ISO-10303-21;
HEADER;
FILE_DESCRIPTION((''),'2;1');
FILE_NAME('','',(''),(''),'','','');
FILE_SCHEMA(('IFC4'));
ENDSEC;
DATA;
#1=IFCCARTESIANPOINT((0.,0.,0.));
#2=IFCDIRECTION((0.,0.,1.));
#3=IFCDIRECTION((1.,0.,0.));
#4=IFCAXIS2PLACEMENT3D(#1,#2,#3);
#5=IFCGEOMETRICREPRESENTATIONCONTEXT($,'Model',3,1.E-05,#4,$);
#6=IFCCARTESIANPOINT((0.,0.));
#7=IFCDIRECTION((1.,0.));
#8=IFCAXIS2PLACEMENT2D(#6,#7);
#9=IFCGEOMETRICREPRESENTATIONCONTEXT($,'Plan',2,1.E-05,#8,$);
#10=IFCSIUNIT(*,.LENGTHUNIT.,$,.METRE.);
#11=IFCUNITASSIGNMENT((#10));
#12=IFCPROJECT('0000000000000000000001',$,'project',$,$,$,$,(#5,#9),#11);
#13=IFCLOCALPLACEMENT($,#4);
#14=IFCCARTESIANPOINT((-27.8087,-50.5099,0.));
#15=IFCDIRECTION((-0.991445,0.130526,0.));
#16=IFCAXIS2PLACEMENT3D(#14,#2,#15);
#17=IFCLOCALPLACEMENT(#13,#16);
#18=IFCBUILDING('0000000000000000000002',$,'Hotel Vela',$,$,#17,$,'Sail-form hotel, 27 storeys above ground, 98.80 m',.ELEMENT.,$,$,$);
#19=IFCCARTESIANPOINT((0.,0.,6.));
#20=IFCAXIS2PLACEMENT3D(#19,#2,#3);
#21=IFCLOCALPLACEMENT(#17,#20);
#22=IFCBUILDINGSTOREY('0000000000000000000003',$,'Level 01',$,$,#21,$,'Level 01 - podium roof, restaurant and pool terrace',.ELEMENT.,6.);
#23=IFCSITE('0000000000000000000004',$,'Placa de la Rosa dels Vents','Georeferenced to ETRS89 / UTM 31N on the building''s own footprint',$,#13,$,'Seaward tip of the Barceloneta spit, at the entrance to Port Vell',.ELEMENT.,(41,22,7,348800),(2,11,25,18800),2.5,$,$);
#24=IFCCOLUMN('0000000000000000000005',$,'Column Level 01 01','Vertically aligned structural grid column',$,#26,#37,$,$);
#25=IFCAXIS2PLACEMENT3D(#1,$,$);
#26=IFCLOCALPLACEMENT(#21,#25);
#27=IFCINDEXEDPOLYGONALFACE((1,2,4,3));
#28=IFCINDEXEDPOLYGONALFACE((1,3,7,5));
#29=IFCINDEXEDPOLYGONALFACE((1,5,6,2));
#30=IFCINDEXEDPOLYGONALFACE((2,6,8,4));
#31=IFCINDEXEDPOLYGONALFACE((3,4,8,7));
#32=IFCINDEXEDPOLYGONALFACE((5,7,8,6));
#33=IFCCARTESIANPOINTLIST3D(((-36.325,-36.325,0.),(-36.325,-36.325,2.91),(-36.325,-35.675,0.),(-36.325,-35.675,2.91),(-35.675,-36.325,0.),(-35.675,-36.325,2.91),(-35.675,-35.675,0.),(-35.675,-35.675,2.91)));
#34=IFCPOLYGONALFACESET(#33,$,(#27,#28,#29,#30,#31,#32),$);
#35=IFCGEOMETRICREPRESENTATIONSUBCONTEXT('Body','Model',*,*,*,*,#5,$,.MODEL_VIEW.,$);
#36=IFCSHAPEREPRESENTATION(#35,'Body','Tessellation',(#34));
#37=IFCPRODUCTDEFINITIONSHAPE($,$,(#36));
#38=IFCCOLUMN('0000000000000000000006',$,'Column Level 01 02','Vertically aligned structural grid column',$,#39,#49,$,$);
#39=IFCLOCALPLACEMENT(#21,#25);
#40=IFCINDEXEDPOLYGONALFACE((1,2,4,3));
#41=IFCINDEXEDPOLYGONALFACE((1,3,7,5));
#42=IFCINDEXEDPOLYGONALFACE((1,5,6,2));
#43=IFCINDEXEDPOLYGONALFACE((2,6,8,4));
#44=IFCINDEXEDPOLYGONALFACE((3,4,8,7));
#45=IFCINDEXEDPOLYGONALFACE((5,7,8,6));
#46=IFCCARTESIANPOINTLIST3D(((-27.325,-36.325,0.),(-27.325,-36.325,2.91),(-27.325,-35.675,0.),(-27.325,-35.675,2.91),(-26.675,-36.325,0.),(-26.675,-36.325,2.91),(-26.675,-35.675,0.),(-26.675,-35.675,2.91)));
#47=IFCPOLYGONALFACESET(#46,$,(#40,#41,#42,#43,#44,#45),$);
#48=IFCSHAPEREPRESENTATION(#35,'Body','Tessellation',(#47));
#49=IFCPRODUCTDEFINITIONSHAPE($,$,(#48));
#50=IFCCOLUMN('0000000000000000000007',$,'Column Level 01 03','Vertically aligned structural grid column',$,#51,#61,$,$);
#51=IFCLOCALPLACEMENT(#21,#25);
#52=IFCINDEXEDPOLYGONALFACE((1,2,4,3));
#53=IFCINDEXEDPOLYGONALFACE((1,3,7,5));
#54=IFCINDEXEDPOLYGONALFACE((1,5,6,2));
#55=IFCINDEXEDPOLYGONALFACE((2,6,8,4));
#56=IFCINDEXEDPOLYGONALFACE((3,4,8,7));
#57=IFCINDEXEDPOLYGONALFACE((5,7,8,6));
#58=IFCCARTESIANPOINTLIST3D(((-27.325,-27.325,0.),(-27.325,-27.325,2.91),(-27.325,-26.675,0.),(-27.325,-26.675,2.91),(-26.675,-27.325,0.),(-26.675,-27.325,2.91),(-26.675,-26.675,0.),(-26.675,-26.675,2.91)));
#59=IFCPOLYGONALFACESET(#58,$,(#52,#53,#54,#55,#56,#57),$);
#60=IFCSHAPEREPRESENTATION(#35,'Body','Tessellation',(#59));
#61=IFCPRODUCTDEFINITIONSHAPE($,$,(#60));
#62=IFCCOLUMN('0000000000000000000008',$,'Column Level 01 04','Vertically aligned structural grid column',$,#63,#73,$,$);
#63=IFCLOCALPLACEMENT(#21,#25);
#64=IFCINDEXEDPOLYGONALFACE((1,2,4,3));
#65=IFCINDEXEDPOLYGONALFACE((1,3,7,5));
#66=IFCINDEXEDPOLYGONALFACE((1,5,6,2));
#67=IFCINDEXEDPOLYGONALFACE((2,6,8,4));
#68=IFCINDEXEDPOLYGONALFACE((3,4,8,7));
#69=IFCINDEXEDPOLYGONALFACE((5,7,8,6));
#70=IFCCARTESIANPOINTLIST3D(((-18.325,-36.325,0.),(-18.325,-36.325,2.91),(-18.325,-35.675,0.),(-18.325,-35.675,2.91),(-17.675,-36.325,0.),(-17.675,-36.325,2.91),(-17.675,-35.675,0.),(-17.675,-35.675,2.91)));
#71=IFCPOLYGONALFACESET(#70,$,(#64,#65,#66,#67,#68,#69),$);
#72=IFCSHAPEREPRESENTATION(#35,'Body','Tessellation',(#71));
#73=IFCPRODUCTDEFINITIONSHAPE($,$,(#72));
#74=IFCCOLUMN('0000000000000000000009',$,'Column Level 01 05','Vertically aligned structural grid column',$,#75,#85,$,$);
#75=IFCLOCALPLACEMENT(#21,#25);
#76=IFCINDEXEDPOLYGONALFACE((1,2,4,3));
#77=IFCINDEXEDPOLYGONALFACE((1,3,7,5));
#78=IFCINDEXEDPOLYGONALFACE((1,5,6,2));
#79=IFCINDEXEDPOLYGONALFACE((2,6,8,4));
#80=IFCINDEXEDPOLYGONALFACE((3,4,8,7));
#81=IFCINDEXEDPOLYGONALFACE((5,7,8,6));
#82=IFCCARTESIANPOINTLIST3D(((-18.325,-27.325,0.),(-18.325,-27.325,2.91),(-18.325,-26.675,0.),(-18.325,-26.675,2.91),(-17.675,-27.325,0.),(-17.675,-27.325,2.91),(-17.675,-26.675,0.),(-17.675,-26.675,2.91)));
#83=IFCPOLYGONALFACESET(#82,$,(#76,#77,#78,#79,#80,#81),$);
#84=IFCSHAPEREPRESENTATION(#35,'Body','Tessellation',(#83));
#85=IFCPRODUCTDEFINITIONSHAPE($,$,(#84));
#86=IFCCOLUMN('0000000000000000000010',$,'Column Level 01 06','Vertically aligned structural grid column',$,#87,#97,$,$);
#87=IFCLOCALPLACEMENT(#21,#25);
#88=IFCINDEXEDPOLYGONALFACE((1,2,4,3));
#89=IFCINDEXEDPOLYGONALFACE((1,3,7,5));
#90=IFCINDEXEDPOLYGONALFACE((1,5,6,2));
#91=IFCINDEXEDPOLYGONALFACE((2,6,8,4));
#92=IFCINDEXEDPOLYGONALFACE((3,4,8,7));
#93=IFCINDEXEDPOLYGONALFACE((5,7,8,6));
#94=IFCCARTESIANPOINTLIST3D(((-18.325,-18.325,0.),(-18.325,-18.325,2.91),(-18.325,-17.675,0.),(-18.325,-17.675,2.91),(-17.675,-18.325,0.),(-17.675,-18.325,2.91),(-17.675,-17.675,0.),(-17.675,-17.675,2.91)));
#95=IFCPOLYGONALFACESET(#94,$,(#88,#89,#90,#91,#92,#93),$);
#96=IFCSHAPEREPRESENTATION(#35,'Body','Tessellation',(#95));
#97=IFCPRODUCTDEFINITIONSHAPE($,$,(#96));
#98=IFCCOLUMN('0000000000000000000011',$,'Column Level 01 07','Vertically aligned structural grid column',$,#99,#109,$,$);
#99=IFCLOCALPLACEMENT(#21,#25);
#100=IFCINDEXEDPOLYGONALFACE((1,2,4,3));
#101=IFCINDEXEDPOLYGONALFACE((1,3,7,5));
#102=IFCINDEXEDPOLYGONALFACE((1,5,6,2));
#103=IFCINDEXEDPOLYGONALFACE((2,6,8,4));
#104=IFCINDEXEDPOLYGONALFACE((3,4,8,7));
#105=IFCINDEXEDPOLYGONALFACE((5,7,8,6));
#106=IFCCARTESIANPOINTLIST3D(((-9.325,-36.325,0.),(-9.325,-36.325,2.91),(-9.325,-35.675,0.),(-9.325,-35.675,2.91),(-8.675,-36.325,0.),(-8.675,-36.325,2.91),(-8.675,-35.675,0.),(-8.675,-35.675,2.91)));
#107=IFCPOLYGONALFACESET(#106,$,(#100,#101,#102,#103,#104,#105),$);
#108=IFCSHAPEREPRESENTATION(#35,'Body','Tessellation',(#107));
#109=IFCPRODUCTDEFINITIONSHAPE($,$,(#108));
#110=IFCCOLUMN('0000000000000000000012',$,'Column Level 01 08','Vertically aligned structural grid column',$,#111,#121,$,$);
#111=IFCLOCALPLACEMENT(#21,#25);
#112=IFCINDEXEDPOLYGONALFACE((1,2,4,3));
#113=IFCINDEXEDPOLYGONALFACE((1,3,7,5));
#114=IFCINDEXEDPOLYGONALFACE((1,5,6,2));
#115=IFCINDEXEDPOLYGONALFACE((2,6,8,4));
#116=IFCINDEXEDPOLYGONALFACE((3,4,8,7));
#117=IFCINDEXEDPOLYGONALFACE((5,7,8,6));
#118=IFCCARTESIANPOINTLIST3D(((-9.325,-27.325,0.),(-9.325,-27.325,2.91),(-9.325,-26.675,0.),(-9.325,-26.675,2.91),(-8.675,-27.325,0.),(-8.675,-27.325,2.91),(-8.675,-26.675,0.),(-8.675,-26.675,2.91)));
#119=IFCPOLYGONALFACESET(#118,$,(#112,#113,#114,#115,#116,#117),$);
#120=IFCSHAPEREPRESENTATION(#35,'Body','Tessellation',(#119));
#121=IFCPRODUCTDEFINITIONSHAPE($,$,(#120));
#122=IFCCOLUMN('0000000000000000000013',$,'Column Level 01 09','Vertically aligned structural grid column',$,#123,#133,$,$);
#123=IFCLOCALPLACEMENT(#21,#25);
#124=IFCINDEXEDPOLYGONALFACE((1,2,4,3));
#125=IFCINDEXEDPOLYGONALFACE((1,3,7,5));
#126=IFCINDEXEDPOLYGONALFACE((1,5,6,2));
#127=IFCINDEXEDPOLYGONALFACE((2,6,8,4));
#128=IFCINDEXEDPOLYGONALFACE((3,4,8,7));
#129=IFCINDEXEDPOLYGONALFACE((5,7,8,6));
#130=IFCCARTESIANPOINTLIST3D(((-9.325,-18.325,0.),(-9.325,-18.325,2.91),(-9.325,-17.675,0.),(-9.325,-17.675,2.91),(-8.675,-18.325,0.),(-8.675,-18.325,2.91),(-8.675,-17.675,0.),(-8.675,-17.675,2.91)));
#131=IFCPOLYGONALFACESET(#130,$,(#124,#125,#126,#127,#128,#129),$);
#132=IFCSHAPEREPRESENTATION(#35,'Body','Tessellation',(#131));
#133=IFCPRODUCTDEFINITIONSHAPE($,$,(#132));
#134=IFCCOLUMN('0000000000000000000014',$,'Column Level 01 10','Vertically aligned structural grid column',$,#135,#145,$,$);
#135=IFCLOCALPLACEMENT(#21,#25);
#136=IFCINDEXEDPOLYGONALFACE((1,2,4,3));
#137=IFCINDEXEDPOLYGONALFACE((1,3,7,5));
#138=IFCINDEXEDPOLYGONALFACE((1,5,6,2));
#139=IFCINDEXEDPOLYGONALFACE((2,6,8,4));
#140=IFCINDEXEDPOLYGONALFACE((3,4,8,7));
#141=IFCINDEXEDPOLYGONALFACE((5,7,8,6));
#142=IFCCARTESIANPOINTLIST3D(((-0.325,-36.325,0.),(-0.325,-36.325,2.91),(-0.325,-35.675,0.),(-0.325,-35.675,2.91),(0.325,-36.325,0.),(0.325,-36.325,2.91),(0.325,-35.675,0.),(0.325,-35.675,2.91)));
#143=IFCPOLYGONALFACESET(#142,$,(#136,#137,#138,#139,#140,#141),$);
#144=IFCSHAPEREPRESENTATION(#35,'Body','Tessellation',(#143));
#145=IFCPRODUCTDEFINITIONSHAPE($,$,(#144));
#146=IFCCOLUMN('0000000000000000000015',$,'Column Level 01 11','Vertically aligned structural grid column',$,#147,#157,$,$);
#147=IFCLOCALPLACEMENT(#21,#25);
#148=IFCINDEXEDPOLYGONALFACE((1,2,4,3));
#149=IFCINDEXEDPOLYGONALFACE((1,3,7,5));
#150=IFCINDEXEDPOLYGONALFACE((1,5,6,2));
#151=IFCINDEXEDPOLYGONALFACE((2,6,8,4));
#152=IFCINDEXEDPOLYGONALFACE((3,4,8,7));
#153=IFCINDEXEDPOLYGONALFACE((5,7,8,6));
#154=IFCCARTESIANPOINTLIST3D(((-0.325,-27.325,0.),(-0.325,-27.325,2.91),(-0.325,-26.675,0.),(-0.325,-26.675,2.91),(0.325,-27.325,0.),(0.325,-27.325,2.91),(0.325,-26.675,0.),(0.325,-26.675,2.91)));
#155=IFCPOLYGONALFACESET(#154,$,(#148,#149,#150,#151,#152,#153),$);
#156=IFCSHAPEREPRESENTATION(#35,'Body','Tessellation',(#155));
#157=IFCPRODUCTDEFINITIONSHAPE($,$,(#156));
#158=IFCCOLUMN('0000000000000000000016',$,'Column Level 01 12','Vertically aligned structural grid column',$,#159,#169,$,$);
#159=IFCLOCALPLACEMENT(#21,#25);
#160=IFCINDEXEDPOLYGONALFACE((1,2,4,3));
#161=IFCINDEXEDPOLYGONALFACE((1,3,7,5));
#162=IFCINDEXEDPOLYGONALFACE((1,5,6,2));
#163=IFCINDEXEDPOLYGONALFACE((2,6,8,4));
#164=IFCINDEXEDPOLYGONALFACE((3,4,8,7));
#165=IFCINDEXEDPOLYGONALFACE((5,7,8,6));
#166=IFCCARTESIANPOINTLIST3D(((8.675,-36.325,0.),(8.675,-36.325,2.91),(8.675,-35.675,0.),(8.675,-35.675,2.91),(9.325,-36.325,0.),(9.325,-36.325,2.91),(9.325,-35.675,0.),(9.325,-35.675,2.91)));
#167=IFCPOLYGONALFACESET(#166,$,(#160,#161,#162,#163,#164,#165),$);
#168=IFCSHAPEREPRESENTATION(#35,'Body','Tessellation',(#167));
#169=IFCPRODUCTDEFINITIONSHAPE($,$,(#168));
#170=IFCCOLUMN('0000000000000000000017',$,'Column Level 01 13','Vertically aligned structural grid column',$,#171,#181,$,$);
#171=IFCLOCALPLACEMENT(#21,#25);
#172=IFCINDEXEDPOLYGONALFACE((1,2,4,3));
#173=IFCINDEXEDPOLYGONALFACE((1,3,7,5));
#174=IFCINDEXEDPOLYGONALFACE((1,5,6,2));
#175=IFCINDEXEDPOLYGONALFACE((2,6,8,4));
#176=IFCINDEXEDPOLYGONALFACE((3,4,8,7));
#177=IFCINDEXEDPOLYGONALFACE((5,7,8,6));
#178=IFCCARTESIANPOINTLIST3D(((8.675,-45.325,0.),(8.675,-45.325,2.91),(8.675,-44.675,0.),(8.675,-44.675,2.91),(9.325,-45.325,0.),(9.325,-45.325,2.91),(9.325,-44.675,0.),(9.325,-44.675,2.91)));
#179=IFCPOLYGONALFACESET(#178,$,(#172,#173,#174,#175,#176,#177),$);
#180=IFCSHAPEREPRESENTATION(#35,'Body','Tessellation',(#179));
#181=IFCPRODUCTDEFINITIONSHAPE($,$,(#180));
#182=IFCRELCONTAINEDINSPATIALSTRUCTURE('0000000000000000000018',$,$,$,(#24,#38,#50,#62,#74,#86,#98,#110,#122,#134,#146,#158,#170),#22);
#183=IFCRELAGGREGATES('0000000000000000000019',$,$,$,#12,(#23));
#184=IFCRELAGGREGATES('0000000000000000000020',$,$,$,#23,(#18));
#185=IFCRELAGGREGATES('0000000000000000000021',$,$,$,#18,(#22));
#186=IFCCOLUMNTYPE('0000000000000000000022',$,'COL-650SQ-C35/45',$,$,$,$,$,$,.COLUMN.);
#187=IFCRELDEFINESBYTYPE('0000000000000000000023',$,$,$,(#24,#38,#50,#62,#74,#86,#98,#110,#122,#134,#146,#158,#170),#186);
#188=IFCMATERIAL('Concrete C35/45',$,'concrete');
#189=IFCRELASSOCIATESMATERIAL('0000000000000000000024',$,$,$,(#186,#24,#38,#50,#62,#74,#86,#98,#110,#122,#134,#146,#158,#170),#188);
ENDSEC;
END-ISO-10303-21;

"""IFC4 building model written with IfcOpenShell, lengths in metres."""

from ifc_helpers import new_model, si_unit, frame, origin_with_axes, origin_2d_with_axis, place, context, subcontext, project, spatial, line, indexed_curve, rectangle, outline, extrude, material, material_profile, profile_set, profile_usage, type_object, element, save


model = new_model("IFC4")

# Units and contexts
model_context = context("Model", 3, precision=1e-05, world=origin_with_axes())
plan_context = context("Plan", 2, precision=1e-05, world=origin_2d_with_axis())
body_context = subcontext(model_context, "Body", "Model", "MODEL_VIEW")
ifc_project = project(units=[si_unit("LENGTHUNIT", "METRE")], contexts=[model_context, plan_context])

# Site, building, storey
site_placement = place(None, origin_with_axes())
site = spatial("IfcSite", under=ifc_project, at=site_placement, Name="Placa de la Rosa dels Vents", Description="Georeferenced to ETRS89 / UTM 31N on the building's own footprint", LongName="Seaward tip of the Barceloneta spit, at the entrance to Port Vell", CompositionType="ELEMENT", RefLatitude=(41, 22, 7, 348800), RefLongitude=(2, 11, 25, 18800), RefElevation=2.5)
building_placement = place(site_placement, frame((-27.8087, -50.5099, 0.0), z_axis=(0.0, 0.0, 1.0), x_axis=(-0.991445, 0.130526, 0.0)))
building = spatial("IfcBuilding", under=site, at=building_placement, Name="Hotel Vela", LongName="Sail-form hotel, 27 storeys above ground, 98.80 m", CompositionType="ELEMENT")
storey_placement = place(building_placement, frame((0.0, 0.0, 6.0), z_axis=(0.0, 0.0, 1.0), x_axis=(1.0, 0.0, 0.0)))
storey = spatial("IfcBuildingStorey", under=building, at=storey_placement, Name="Level 01", LongName="Level 01 - podium roof, restaurant and pool terrace", CompositionType="ELEMENT", Elevation=6.0)

# Columns
ifc_material = material(Name="Concrete C35/45", Category="concrete")
ifc_material_profile = material_profile(ifc_material, rectangle(XDim=0.65, YDim=0.65))
ifc_profile_set = profile_set([ifc_material_profile], Name="COL-650SQ-C35/45")
ifc_profile_usage_1 = profile_usage(ifc_profile_set)
column_type = type_object("IfcColumnType", Name="COL-650SQ-C35/45", PredefinedType="COLUMN", material=ifc_profile_set)
column_1_placement = place(storey_placement, frame((-36.325, -36.325, 0.0), z_axis=(0.0, 0.0, 1.0), x_axis=(1.0, 0.0, 0.0)))
element("IfcColumn", 1, at=column_1_placement, inside=storey, type_object=column_type, material=ifc_profile_usage_1, Name="Column Level 01 01", Description="Vertically aligned structural grid column", context=body_context, shape_type="SweptSolid", body=[
    extrude(outline(indexed_curve([(0.0, 0.0), (0.65, 0.0), (0.65, 0.65), (0.0, 0.65)], segments=[line(1, 2, 3, 4, 1)])), origin_with_axes(), (0.0, 0.0, 1.0), 2.91),
])
ifc_profile_usage_2 = profile_usage(ifc_profile_set)
column_2_placement = place(storey_placement, frame((-27.325, -36.325, 0.0), z_axis=(0.0, 0.0, 1.0), x_axis=(1.0, 0.0, 0.0)))
element("IfcColumn", 2, at=column_2_placement, inside=storey, type_object=column_type, material=ifc_profile_usage_2, Name="Column Level 01 02", Description="Vertically aligned structural grid column", context=body_context, shape_type="SweptSolid", body=[
    extrude(outline(indexed_curve([(0.0, 0.0), (0.65, 0.0), (0.65, 0.65), (0.0, 0.65)], segments=[line(1, 2, 3, 4, 1)])), origin_with_axes(), (0.0, 0.0, 1.0), 2.91),
])
ifc_profile_usage_3 = profile_usage(ifc_profile_set)
column_3_placement = place(storey_placement, frame((-27.325, -27.325, 0.0), z_axis=(0.0, 0.0, 1.0), x_axis=(1.0, 0.0, 0.0)))
element("IfcColumn", 3, at=column_3_placement, inside=storey, type_object=column_type, material=ifc_profile_usage_3, Name="Column Level 01 03", Description="Vertically aligned structural grid column", context=body_context, shape_type="SweptSolid", body=[
    extrude(outline(indexed_curve([(0.0, 0.0), (0.65, 0.0), (0.65, 0.65), (0.0, 0.65)], segments=[line(1, 2, 3, 4, 1)])), origin_with_axes(), (0.0, 0.0, 1.0), 2.91),
])
ifc_profile_usage_4 = profile_usage(ifc_profile_set)
column_4_placement = place(storey_placement, frame((-18.325, -36.325, 0.0), z_axis=(0.0, 0.0, 1.0), x_axis=(1.0, 0.0, 0.0)))
element("IfcColumn", 4, at=column_4_placement, inside=storey, type_object=column_type, material=ifc_profile_usage_4, Name="Column Level 01 04", Description="Vertically aligned structural grid column", context=body_context, shape_type="SweptSolid", body=[
    extrude(outline(indexed_curve([(0.0, 0.0), (0.65, 0.0), (0.65, 0.65), (0.0, 0.65)], segments=[line(1, 2, 3, 4, 1)])), origin_with_axes(), (0.0, 0.0, 1.0), 2.91),
])
ifc_profile_usage_5 = profile_usage(ifc_profile_set)
column_5_placement = place(storey_placement, frame((-18.325, -27.325, 0.0), z_axis=(0.0, 0.0, 1.0), x_axis=(1.0, 0.0, 0.0)))
element("IfcColumn", 5, at=column_5_placement, inside=storey, type_object=column_type, material=ifc_profile_usage_5, Name="Column Level 01 05", Description="Vertically aligned structural grid column", context=body_context, shape_type="SweptSolid", body=[
    extrude(outline(indexed_curve([(0.0, 0.0), (0.65, 0.0), (0.65, 0.65), (0.0, 0.65)], segments=[line(1, 2, 3, 4, 1)])), origin_with_axes(), (0.0, 0.0, 1.0), 2.91),
])
ifc_profile_usage_6 = profile_usage(ifc_profile_set)
column_6_placement = place(storey_placement, frame((-18.325, -18.325, 0.0), z_axis=(0.0, 0.0, 1.0), x_axis=(1.0, 0.0, 0.0)))
element("IfcColumn", 6, at=column_6_placement, inside=storey, type_object=column_type, material=ifc_profile_usage_6, Name="Column Level 01 06", Description="Vertically aligned structural grid column", context=body_context, shape_type="SweptSolid", body=[
    extrude(outline(indexed_curve([(0.0, 0.0), (0.65, 0.0), (0.65, 0.65), (0.0, 0.65)], segments=[line(1, 2, 3, 4, 1)])), origin_with_axes(), (0.0, 0.0, 1.0), 2.91),
])
ifc_profile_usage_7 = profile_usage(ifc_profile_set)
column_7_placement = place(storey_placement, frame((-9.325, -36.325, 0.0), z_axis=(0.0, 0.0, 1.0), x_axis=(1.0, 0.0, 0.0)))
element("IfcColumn", 7, at=column_7_placement, inside=storey, type_object=column_type, material=ifc_profile_usage_7, Name="Column Level 01 07", Description="Vertically aligned structural grid column", context=body_context, shape_type="SweptSolid", body=[
    extrude(outline(indexed_curve([(0.0, 0.0), (0.65, 0.0), (0.65, 0.65), (0.0, 0.65)], segments=[line(1, 2, 3, 4, 1)])), origin_with_axes(), (0.0, 0.0, 1.0), 2.91),
])
ifc_profile_usage_8 = profile_usage(ifc_profile_set)
column_8_placement = place(storey_placement, frame((-9.325, -27.325, 0.0), z_axis=(0.0, 0.0, 1.0), x_axis=(1.0, 0.0, 0.0)))
element("IfcColumn", 8, at=column_8_placement, inside=storey, type_object=column_type, material=ifc_profile_usage_8, Name="Column Level 01 08", Description="Vertically aligned structural grid column", context=body_context, shape_type="SweptSolid", body=[
    extrude(outline(indexed_curve([(0.0, 0.0), (0.65, 0.0), (0.65, 0.65), (0.0, 0.65)], segments=[line(1, 2, 3, 4, 1)])), origin_with_axes(), (0.0, 0.0, 1.0), 2.91),
])
ifc_profile_usage_9 = profile_usage(ifc_profile_set)
column_9_placement = place(storey_placement, frame((-9.325, -18.325, 0.0), z_axis=(0.0, 0.0, 1.0), x_axis=(1.0, 0.0, 0.0)))
element("IfcColumn", 9, at=column_9_placement, inside=storey, type_object=column_type, material=ifc_profile_usage_9, Name="Column Level 01 09", Description="Vertically aligned structural grid column", context=body_context, shape_type="SweptSolid", body=[
    extrude(outline(indexed_curve([(0.0, 0.0), (0.65, 0.0), (0.65, 0.65), (0.0, 0.65)], segments=[line(1, 2, 3, 4, 1)])), origin_with_axes(), (0.0, 0.0, 1.0), 2.91),
])
ifc_profile_usage_10 = profile_usage(ifc_profile_set)
column_10_placement = place(storey_placement, frame((-0.325, -36.325, 0.0), z_axis=(0.0, 0.0, 1.0), x_axis=(1.0, 0.0, 0.0)))
element("IfcColumn", 10, at=column_10_placement, inside=storey, type_object=column_type, material=ifc_profile_usage_10, Name="Column Level 01 10", Description="Vertically aligned structural grid column", context=body_context, shape_type="SweptSolid", body=[
    extrude(outline(indexed_curve([(0.0, 0.0), (0.65, 0.0), (0.65, 0.65), (0.0, 0.65)], segments=[line(1, 2, 3, 4, 1)])), origin_with_axes(), (0.0, 0.0, 1.0), 2.91),
])
ifc_profile_usage_11 = profile_usage(ifc_profile_set)
column_11_placement = place(storey_placement, frame((-0.325, -27.325, 0.0), z_axis=(0.0, 0.0, 1.0), x_axis=(1.0, 0.0, 0.0)))
element("IfcColumn", 11, at=column_11_placement, inside=storey, type_object=column_type, material=ifc_profile_usage_11, Name="Column Level 01 11", Description="Vertically aligned structural grid column", context=body_context, shape_type="SweptSolid", body=[
    extrude(outline(indexed_curve([(0.0, 0.0), (0.65, 0.0), (0.65, 0.65), (0.0, 0.65)], segments=[line(1, 2, 3, 4, 1)])), origin_with_axes(), (0.0, 0.0, 1.0), 2.91),
])
ifc_profile_usage_12 = profile_usage(ifc_profile_set)
column_12_placement = place(storey_placement, frame((8.675, -36.325, 0.0), z_axis=(0.0, 0.0, 1.0), x_axis=(1.0, 0.0, 0.0)))
element("IfcColumn", 12, at=column_12_placement, inside=storey, type_object=column_type, material=ifc_profile_usage_12, Name="Column Level 01 12", Description="Vertically aligned structural grid column", context=body_context, shape_type="SweptSolid", body=[
    extrude(outline(indexed_curve([(0.0, 0.0), (0.65, 0.0), (0.65, 0.65), (0.0, 0.65)], segments=[line(1, 2, 3, 4, 1)])), origin_with_axes(), (0.0, 0.0, 1.0), 2.91),
])
ifc_profile_usage_13 = profile_usage(ifc_profile_set)
column_13_placement = place(storey_placement, frame((8.675, -45.325, 0.0), z_axis=(0.0, 0.0, 1.0), x_axis=(1.0, 0.0, 0.0)))
element("IfcColumn", 13, at=column_13_placement, inside=storey, type_object=column_type, material=ifc_profile_usage_13, Name="Column Level 01 13", Description="Vertically aligned structural grid column", context=body_context, shape_type="SweptSolid", body=[
    extrude(outline(indexed_curve([(0.0, 0.0), (0.65, 0.0), (0.65, 0.65), (0.0, 0.65)], segments=[line(1, 2, 3, 4, 1)])), origin_with_axes(), (0.0, 0.0, 1.0), 2.91),
])

save(model, "model.ifc")
